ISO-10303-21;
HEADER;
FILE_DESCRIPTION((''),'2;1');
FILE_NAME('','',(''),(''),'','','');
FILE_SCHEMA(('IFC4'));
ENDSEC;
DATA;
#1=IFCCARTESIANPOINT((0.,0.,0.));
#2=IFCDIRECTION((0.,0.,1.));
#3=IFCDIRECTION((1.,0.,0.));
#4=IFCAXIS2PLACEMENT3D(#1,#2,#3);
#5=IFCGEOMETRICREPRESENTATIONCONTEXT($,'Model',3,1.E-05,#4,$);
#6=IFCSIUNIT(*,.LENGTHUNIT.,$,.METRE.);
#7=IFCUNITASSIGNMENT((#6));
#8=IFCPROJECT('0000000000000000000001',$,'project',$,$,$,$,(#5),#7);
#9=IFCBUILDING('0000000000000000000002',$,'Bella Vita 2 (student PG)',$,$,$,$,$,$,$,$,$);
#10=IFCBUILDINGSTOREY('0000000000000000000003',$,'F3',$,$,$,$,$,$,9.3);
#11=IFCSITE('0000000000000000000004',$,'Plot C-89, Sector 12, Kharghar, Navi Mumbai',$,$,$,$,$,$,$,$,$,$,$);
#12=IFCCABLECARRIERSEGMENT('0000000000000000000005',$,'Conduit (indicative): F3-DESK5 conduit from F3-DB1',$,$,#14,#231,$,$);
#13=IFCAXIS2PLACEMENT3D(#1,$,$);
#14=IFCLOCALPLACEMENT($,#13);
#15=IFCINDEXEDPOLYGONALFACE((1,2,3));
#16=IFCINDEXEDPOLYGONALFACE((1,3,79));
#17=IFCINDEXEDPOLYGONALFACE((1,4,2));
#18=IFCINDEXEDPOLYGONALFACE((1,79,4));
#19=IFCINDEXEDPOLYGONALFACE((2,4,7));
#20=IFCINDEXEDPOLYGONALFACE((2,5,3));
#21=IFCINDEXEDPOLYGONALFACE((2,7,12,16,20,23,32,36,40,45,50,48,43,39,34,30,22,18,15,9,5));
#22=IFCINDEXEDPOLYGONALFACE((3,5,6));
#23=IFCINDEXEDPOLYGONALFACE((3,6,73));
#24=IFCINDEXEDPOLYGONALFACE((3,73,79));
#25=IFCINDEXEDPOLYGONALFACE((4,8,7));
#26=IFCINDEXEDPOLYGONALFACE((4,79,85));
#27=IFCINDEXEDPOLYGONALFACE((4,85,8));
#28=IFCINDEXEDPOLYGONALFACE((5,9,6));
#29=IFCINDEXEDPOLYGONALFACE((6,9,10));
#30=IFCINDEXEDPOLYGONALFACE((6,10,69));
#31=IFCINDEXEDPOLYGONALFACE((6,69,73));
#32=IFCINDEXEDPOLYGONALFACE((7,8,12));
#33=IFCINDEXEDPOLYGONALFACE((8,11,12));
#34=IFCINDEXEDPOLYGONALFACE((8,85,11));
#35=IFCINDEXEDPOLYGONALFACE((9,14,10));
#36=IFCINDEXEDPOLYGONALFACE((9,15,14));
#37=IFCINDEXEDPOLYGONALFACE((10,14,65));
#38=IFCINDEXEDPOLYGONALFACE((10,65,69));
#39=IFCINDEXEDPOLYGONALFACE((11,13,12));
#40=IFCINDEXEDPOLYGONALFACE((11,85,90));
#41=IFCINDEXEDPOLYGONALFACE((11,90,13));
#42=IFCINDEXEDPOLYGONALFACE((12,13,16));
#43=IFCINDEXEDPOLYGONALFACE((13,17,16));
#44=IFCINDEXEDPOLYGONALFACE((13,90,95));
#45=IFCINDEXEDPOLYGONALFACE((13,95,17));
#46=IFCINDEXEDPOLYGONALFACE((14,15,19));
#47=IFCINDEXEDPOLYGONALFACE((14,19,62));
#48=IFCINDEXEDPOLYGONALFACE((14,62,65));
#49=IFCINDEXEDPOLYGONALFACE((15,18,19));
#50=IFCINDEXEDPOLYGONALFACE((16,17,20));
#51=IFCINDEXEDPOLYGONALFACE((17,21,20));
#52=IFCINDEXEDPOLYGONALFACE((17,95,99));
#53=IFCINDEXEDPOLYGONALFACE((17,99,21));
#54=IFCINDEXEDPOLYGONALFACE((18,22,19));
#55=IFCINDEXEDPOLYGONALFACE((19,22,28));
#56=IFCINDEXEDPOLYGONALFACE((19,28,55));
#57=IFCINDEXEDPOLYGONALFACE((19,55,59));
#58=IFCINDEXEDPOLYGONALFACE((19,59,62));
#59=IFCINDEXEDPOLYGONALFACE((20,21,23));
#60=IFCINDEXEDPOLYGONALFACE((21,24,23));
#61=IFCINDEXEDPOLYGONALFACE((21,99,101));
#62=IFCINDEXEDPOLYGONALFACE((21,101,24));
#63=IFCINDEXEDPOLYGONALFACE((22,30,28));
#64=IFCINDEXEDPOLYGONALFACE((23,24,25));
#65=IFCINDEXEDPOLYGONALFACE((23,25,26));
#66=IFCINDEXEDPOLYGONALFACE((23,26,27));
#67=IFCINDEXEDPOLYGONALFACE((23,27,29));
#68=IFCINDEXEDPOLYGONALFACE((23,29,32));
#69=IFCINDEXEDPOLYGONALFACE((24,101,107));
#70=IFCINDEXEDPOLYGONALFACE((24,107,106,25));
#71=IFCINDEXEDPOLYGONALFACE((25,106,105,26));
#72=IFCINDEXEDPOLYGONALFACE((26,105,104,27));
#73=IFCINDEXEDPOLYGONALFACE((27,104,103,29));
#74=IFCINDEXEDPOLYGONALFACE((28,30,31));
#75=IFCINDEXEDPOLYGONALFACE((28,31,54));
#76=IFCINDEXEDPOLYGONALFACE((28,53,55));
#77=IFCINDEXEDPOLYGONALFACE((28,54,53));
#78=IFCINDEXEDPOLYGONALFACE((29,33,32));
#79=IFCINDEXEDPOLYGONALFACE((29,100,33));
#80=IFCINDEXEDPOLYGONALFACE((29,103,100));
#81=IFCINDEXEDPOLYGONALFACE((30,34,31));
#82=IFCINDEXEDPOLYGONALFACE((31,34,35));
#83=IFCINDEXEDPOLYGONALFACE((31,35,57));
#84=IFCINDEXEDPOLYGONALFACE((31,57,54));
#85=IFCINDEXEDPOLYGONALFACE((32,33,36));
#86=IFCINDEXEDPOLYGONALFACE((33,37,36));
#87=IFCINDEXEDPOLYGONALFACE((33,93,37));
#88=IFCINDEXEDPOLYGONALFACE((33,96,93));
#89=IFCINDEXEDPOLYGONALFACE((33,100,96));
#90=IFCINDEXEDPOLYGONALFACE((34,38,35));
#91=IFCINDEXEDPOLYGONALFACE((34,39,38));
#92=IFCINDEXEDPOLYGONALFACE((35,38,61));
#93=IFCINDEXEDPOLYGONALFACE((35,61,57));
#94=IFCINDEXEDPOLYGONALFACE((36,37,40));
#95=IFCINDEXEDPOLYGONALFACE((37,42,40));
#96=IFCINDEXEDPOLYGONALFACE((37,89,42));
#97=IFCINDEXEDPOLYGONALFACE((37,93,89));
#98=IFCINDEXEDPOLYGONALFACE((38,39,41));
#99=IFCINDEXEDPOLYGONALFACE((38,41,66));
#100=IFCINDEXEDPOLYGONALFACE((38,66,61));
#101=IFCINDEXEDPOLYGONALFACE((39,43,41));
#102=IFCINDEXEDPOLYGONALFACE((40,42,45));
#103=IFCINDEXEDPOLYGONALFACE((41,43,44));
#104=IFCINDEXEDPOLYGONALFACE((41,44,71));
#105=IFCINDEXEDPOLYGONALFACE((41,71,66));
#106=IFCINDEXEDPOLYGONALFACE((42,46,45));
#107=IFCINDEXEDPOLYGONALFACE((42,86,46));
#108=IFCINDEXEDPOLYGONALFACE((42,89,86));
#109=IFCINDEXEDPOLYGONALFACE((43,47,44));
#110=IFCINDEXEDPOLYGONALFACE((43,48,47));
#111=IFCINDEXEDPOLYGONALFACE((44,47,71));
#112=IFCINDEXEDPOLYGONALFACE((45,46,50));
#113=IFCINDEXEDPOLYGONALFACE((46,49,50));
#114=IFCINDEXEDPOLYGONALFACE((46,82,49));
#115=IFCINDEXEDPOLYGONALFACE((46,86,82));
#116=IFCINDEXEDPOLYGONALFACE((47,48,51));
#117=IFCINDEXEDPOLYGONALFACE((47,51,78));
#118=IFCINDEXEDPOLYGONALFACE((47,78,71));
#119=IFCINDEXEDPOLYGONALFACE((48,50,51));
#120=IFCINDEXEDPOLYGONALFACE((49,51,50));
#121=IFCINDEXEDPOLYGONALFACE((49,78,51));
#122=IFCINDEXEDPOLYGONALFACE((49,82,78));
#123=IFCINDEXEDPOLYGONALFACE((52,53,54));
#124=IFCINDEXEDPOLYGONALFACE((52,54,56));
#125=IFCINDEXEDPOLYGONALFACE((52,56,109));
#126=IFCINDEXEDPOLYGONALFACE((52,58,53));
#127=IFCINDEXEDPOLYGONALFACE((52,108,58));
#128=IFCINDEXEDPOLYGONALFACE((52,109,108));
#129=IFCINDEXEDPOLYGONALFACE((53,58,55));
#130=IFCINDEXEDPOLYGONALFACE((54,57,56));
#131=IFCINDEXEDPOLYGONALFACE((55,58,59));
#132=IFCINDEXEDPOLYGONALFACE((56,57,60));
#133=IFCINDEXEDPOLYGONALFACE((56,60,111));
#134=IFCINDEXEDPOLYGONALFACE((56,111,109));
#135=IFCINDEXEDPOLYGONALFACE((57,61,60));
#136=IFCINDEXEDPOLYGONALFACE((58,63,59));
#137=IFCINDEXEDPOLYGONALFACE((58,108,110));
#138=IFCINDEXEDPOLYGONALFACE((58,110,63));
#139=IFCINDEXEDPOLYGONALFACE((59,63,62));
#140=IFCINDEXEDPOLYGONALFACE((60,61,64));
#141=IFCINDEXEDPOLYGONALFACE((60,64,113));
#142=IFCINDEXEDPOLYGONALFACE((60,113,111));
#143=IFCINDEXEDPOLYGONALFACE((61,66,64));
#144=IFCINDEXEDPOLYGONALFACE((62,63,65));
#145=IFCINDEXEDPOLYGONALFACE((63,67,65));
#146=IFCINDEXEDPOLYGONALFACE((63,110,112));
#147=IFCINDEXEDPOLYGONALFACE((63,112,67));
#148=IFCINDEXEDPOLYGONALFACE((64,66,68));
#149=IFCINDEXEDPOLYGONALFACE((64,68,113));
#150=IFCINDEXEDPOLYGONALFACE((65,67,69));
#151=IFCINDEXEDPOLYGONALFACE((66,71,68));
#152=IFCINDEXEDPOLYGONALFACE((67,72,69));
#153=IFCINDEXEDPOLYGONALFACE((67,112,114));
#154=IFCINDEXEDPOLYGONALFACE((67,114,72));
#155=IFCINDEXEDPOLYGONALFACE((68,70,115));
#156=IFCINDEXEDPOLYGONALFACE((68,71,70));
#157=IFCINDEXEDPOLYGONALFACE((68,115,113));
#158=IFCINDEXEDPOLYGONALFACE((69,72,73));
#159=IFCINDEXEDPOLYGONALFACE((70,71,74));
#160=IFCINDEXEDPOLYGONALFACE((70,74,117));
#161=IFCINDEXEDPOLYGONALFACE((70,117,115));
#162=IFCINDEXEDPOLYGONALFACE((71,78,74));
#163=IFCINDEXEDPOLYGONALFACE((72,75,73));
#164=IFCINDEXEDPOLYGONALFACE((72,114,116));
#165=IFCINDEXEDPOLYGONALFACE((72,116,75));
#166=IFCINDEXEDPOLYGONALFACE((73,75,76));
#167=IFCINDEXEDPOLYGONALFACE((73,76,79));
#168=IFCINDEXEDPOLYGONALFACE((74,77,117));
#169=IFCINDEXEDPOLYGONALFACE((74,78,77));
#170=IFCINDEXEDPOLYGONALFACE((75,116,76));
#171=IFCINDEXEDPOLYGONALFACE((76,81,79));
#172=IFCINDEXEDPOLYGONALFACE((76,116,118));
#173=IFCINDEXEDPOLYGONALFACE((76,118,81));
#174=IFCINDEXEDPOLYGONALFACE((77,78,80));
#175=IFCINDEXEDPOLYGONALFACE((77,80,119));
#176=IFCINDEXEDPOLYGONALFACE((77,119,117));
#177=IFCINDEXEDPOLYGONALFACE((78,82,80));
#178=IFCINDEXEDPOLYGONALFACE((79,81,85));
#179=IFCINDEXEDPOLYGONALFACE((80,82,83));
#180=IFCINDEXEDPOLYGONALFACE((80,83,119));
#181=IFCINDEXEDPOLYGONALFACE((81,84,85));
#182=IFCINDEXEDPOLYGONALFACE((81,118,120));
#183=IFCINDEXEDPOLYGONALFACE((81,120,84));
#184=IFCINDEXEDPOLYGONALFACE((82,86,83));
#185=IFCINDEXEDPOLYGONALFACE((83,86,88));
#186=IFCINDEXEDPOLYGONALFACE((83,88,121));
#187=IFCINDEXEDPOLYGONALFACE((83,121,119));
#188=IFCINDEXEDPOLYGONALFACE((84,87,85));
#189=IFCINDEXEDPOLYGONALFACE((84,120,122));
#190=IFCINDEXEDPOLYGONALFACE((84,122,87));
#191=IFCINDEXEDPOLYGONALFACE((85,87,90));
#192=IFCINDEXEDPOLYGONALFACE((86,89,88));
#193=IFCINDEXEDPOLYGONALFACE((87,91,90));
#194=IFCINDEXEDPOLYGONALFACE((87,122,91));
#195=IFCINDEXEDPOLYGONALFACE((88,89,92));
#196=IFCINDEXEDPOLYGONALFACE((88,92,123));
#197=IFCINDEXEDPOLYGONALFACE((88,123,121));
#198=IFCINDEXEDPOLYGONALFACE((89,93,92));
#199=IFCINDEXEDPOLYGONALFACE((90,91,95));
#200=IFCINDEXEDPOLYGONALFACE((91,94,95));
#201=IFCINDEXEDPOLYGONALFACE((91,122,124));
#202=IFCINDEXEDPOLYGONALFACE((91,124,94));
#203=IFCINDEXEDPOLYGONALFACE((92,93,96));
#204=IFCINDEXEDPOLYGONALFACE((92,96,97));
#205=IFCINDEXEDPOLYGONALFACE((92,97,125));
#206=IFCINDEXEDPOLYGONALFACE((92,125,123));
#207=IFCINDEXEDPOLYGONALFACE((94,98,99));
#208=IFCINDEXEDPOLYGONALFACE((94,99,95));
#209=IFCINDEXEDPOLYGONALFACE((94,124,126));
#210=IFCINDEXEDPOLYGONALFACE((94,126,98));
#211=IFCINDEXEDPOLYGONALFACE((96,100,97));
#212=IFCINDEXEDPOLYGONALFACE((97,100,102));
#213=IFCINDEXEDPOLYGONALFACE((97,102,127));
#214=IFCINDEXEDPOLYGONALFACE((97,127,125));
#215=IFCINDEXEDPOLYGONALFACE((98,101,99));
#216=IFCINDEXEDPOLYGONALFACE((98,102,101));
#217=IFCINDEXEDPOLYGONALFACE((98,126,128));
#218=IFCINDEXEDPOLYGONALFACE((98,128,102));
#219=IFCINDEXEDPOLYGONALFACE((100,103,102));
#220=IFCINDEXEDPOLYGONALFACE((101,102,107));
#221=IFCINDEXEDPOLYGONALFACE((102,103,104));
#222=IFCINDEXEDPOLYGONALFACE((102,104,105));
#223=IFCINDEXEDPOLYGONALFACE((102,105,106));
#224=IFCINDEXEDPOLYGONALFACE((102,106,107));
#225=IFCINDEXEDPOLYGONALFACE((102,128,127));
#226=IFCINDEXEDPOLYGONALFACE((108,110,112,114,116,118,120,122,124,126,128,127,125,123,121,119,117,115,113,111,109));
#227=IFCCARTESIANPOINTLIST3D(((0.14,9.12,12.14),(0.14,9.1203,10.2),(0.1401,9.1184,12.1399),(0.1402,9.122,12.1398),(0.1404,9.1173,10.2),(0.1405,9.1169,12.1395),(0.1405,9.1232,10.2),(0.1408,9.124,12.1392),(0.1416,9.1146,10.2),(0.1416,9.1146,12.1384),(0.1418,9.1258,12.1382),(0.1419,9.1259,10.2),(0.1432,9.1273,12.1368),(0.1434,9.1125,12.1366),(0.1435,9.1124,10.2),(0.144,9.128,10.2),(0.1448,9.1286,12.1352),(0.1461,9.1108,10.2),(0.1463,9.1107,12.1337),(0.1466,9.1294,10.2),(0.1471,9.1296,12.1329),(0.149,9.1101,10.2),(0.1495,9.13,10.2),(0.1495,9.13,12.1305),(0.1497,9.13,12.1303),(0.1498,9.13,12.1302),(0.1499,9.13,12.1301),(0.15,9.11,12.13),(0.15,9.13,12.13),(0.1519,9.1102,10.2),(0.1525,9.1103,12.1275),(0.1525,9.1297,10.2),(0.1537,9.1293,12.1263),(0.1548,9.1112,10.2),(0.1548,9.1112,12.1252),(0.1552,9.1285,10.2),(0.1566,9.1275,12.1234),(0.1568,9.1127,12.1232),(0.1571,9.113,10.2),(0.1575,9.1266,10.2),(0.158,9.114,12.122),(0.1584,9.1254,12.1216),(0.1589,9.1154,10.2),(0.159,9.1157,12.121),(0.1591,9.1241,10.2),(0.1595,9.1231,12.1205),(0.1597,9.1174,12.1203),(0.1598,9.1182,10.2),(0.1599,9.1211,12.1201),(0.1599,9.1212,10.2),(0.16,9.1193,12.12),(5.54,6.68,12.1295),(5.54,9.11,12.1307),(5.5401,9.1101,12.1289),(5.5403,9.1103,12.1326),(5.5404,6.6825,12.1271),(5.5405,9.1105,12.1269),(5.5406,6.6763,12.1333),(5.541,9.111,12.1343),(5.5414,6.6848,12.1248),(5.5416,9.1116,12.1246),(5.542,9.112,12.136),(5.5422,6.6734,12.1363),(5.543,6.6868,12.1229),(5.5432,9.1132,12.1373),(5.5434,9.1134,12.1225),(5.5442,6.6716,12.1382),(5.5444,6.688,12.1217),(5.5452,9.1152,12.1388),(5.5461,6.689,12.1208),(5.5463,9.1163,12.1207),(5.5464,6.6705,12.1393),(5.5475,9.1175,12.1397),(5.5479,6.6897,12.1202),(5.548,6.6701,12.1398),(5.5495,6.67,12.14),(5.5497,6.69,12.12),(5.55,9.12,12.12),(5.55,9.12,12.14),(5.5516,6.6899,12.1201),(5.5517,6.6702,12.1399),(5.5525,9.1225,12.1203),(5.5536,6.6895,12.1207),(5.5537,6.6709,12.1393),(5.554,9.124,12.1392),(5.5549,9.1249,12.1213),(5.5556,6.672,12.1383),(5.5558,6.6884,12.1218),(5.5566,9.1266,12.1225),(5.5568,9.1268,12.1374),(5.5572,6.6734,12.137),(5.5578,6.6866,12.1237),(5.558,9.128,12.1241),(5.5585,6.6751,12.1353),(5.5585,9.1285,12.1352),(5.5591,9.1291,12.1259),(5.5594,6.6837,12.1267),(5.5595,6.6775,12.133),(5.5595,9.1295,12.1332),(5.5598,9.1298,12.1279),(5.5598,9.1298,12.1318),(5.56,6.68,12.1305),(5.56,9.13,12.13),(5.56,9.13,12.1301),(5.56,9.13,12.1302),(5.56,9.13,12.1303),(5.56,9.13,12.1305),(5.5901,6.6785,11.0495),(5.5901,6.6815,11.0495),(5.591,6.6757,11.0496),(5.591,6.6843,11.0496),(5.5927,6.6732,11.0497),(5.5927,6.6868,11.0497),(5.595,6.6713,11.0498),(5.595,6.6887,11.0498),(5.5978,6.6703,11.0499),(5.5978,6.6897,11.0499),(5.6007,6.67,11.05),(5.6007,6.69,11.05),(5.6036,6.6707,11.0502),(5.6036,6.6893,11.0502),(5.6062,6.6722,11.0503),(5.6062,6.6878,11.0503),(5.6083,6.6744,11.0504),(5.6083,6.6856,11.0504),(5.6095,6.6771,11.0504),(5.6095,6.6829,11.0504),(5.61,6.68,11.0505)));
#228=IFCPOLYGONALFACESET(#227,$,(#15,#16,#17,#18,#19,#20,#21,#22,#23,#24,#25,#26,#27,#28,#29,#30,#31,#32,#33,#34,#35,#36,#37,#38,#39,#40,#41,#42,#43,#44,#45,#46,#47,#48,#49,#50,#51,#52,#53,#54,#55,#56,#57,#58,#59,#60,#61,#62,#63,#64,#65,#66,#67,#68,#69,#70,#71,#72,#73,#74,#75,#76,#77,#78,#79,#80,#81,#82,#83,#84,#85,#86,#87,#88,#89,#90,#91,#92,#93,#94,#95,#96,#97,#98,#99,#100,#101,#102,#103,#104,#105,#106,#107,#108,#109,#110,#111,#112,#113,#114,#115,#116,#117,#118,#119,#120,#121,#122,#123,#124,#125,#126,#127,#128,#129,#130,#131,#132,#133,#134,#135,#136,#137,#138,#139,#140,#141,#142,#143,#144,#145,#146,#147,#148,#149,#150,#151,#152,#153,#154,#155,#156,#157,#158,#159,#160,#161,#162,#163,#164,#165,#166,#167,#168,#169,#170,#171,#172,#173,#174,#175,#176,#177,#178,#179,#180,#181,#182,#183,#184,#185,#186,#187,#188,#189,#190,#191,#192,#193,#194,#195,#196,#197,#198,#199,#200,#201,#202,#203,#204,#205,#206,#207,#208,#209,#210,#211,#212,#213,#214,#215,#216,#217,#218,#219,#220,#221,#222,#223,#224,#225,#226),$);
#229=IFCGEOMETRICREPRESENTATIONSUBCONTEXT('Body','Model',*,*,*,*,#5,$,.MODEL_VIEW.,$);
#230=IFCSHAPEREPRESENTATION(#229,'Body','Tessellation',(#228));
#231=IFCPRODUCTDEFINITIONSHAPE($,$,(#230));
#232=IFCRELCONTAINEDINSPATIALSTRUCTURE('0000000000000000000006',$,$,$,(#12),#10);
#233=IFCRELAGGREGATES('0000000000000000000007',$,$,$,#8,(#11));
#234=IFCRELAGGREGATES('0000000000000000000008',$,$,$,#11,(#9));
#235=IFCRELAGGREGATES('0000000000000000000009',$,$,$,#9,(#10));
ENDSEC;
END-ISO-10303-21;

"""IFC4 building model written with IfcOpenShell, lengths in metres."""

from ifc_helpers import new_model, entity, si_unit, origin, origin_with_axes, place, context, subcontext, project, spatial, element, save


model = new_model("IFC4")

# Units and contexts
model_context = context("Model", 3, precision=1e-05, world=origin_with_axes())
body_context = subcontext(model_context, "Body", "Model", "MODEL_VIEW")
ifc_project = project(units=[si_unit("LENGTHUNIT", "METRE")], contexts=[model_context])

# Site, building, storey
site = spatial("IfcSite", under=ifc_project, Name="Plot C-89, Sector 12, Kharghar, Navi Mumbai")
building = spatial("IfcBuilding", under=site, Name="Bella Vita 2 (student PG)")
storey = spatial("IfcBuildingStorey", under=building, Name="F3", Elevation=9.3)

# Cable carrier segment
cable_carrier_segment_1_placement = place(None, origin())
element("IfcCableCarrierSegment", 1, at=cable_carrier_segment_1_placement, inside=storey, Name="Conduit (indicative): F3-DESK5 conduit from F3-DB1", context=body_context, shape_type="AdvancedSweptSolid", body=[
    entity("IfcSweptDiskSolid", entity("IfcPolyline", [entity("IfcCartesianPoint", [5.6, 6.68, 11.05]), entity("IfcCartesianPoint", [5.55, 6.68, 12.13]), entity("IfcCartesianPoint", [5.55, 9.12, 12.13]), entity("IfcCartesianPoint", [0.15, 9.12, 12.13]), entity("IfcCartesianPoint", [0.15, 9.12, 10.2])]), 0.01),
])

save(model, "model.ifc")
